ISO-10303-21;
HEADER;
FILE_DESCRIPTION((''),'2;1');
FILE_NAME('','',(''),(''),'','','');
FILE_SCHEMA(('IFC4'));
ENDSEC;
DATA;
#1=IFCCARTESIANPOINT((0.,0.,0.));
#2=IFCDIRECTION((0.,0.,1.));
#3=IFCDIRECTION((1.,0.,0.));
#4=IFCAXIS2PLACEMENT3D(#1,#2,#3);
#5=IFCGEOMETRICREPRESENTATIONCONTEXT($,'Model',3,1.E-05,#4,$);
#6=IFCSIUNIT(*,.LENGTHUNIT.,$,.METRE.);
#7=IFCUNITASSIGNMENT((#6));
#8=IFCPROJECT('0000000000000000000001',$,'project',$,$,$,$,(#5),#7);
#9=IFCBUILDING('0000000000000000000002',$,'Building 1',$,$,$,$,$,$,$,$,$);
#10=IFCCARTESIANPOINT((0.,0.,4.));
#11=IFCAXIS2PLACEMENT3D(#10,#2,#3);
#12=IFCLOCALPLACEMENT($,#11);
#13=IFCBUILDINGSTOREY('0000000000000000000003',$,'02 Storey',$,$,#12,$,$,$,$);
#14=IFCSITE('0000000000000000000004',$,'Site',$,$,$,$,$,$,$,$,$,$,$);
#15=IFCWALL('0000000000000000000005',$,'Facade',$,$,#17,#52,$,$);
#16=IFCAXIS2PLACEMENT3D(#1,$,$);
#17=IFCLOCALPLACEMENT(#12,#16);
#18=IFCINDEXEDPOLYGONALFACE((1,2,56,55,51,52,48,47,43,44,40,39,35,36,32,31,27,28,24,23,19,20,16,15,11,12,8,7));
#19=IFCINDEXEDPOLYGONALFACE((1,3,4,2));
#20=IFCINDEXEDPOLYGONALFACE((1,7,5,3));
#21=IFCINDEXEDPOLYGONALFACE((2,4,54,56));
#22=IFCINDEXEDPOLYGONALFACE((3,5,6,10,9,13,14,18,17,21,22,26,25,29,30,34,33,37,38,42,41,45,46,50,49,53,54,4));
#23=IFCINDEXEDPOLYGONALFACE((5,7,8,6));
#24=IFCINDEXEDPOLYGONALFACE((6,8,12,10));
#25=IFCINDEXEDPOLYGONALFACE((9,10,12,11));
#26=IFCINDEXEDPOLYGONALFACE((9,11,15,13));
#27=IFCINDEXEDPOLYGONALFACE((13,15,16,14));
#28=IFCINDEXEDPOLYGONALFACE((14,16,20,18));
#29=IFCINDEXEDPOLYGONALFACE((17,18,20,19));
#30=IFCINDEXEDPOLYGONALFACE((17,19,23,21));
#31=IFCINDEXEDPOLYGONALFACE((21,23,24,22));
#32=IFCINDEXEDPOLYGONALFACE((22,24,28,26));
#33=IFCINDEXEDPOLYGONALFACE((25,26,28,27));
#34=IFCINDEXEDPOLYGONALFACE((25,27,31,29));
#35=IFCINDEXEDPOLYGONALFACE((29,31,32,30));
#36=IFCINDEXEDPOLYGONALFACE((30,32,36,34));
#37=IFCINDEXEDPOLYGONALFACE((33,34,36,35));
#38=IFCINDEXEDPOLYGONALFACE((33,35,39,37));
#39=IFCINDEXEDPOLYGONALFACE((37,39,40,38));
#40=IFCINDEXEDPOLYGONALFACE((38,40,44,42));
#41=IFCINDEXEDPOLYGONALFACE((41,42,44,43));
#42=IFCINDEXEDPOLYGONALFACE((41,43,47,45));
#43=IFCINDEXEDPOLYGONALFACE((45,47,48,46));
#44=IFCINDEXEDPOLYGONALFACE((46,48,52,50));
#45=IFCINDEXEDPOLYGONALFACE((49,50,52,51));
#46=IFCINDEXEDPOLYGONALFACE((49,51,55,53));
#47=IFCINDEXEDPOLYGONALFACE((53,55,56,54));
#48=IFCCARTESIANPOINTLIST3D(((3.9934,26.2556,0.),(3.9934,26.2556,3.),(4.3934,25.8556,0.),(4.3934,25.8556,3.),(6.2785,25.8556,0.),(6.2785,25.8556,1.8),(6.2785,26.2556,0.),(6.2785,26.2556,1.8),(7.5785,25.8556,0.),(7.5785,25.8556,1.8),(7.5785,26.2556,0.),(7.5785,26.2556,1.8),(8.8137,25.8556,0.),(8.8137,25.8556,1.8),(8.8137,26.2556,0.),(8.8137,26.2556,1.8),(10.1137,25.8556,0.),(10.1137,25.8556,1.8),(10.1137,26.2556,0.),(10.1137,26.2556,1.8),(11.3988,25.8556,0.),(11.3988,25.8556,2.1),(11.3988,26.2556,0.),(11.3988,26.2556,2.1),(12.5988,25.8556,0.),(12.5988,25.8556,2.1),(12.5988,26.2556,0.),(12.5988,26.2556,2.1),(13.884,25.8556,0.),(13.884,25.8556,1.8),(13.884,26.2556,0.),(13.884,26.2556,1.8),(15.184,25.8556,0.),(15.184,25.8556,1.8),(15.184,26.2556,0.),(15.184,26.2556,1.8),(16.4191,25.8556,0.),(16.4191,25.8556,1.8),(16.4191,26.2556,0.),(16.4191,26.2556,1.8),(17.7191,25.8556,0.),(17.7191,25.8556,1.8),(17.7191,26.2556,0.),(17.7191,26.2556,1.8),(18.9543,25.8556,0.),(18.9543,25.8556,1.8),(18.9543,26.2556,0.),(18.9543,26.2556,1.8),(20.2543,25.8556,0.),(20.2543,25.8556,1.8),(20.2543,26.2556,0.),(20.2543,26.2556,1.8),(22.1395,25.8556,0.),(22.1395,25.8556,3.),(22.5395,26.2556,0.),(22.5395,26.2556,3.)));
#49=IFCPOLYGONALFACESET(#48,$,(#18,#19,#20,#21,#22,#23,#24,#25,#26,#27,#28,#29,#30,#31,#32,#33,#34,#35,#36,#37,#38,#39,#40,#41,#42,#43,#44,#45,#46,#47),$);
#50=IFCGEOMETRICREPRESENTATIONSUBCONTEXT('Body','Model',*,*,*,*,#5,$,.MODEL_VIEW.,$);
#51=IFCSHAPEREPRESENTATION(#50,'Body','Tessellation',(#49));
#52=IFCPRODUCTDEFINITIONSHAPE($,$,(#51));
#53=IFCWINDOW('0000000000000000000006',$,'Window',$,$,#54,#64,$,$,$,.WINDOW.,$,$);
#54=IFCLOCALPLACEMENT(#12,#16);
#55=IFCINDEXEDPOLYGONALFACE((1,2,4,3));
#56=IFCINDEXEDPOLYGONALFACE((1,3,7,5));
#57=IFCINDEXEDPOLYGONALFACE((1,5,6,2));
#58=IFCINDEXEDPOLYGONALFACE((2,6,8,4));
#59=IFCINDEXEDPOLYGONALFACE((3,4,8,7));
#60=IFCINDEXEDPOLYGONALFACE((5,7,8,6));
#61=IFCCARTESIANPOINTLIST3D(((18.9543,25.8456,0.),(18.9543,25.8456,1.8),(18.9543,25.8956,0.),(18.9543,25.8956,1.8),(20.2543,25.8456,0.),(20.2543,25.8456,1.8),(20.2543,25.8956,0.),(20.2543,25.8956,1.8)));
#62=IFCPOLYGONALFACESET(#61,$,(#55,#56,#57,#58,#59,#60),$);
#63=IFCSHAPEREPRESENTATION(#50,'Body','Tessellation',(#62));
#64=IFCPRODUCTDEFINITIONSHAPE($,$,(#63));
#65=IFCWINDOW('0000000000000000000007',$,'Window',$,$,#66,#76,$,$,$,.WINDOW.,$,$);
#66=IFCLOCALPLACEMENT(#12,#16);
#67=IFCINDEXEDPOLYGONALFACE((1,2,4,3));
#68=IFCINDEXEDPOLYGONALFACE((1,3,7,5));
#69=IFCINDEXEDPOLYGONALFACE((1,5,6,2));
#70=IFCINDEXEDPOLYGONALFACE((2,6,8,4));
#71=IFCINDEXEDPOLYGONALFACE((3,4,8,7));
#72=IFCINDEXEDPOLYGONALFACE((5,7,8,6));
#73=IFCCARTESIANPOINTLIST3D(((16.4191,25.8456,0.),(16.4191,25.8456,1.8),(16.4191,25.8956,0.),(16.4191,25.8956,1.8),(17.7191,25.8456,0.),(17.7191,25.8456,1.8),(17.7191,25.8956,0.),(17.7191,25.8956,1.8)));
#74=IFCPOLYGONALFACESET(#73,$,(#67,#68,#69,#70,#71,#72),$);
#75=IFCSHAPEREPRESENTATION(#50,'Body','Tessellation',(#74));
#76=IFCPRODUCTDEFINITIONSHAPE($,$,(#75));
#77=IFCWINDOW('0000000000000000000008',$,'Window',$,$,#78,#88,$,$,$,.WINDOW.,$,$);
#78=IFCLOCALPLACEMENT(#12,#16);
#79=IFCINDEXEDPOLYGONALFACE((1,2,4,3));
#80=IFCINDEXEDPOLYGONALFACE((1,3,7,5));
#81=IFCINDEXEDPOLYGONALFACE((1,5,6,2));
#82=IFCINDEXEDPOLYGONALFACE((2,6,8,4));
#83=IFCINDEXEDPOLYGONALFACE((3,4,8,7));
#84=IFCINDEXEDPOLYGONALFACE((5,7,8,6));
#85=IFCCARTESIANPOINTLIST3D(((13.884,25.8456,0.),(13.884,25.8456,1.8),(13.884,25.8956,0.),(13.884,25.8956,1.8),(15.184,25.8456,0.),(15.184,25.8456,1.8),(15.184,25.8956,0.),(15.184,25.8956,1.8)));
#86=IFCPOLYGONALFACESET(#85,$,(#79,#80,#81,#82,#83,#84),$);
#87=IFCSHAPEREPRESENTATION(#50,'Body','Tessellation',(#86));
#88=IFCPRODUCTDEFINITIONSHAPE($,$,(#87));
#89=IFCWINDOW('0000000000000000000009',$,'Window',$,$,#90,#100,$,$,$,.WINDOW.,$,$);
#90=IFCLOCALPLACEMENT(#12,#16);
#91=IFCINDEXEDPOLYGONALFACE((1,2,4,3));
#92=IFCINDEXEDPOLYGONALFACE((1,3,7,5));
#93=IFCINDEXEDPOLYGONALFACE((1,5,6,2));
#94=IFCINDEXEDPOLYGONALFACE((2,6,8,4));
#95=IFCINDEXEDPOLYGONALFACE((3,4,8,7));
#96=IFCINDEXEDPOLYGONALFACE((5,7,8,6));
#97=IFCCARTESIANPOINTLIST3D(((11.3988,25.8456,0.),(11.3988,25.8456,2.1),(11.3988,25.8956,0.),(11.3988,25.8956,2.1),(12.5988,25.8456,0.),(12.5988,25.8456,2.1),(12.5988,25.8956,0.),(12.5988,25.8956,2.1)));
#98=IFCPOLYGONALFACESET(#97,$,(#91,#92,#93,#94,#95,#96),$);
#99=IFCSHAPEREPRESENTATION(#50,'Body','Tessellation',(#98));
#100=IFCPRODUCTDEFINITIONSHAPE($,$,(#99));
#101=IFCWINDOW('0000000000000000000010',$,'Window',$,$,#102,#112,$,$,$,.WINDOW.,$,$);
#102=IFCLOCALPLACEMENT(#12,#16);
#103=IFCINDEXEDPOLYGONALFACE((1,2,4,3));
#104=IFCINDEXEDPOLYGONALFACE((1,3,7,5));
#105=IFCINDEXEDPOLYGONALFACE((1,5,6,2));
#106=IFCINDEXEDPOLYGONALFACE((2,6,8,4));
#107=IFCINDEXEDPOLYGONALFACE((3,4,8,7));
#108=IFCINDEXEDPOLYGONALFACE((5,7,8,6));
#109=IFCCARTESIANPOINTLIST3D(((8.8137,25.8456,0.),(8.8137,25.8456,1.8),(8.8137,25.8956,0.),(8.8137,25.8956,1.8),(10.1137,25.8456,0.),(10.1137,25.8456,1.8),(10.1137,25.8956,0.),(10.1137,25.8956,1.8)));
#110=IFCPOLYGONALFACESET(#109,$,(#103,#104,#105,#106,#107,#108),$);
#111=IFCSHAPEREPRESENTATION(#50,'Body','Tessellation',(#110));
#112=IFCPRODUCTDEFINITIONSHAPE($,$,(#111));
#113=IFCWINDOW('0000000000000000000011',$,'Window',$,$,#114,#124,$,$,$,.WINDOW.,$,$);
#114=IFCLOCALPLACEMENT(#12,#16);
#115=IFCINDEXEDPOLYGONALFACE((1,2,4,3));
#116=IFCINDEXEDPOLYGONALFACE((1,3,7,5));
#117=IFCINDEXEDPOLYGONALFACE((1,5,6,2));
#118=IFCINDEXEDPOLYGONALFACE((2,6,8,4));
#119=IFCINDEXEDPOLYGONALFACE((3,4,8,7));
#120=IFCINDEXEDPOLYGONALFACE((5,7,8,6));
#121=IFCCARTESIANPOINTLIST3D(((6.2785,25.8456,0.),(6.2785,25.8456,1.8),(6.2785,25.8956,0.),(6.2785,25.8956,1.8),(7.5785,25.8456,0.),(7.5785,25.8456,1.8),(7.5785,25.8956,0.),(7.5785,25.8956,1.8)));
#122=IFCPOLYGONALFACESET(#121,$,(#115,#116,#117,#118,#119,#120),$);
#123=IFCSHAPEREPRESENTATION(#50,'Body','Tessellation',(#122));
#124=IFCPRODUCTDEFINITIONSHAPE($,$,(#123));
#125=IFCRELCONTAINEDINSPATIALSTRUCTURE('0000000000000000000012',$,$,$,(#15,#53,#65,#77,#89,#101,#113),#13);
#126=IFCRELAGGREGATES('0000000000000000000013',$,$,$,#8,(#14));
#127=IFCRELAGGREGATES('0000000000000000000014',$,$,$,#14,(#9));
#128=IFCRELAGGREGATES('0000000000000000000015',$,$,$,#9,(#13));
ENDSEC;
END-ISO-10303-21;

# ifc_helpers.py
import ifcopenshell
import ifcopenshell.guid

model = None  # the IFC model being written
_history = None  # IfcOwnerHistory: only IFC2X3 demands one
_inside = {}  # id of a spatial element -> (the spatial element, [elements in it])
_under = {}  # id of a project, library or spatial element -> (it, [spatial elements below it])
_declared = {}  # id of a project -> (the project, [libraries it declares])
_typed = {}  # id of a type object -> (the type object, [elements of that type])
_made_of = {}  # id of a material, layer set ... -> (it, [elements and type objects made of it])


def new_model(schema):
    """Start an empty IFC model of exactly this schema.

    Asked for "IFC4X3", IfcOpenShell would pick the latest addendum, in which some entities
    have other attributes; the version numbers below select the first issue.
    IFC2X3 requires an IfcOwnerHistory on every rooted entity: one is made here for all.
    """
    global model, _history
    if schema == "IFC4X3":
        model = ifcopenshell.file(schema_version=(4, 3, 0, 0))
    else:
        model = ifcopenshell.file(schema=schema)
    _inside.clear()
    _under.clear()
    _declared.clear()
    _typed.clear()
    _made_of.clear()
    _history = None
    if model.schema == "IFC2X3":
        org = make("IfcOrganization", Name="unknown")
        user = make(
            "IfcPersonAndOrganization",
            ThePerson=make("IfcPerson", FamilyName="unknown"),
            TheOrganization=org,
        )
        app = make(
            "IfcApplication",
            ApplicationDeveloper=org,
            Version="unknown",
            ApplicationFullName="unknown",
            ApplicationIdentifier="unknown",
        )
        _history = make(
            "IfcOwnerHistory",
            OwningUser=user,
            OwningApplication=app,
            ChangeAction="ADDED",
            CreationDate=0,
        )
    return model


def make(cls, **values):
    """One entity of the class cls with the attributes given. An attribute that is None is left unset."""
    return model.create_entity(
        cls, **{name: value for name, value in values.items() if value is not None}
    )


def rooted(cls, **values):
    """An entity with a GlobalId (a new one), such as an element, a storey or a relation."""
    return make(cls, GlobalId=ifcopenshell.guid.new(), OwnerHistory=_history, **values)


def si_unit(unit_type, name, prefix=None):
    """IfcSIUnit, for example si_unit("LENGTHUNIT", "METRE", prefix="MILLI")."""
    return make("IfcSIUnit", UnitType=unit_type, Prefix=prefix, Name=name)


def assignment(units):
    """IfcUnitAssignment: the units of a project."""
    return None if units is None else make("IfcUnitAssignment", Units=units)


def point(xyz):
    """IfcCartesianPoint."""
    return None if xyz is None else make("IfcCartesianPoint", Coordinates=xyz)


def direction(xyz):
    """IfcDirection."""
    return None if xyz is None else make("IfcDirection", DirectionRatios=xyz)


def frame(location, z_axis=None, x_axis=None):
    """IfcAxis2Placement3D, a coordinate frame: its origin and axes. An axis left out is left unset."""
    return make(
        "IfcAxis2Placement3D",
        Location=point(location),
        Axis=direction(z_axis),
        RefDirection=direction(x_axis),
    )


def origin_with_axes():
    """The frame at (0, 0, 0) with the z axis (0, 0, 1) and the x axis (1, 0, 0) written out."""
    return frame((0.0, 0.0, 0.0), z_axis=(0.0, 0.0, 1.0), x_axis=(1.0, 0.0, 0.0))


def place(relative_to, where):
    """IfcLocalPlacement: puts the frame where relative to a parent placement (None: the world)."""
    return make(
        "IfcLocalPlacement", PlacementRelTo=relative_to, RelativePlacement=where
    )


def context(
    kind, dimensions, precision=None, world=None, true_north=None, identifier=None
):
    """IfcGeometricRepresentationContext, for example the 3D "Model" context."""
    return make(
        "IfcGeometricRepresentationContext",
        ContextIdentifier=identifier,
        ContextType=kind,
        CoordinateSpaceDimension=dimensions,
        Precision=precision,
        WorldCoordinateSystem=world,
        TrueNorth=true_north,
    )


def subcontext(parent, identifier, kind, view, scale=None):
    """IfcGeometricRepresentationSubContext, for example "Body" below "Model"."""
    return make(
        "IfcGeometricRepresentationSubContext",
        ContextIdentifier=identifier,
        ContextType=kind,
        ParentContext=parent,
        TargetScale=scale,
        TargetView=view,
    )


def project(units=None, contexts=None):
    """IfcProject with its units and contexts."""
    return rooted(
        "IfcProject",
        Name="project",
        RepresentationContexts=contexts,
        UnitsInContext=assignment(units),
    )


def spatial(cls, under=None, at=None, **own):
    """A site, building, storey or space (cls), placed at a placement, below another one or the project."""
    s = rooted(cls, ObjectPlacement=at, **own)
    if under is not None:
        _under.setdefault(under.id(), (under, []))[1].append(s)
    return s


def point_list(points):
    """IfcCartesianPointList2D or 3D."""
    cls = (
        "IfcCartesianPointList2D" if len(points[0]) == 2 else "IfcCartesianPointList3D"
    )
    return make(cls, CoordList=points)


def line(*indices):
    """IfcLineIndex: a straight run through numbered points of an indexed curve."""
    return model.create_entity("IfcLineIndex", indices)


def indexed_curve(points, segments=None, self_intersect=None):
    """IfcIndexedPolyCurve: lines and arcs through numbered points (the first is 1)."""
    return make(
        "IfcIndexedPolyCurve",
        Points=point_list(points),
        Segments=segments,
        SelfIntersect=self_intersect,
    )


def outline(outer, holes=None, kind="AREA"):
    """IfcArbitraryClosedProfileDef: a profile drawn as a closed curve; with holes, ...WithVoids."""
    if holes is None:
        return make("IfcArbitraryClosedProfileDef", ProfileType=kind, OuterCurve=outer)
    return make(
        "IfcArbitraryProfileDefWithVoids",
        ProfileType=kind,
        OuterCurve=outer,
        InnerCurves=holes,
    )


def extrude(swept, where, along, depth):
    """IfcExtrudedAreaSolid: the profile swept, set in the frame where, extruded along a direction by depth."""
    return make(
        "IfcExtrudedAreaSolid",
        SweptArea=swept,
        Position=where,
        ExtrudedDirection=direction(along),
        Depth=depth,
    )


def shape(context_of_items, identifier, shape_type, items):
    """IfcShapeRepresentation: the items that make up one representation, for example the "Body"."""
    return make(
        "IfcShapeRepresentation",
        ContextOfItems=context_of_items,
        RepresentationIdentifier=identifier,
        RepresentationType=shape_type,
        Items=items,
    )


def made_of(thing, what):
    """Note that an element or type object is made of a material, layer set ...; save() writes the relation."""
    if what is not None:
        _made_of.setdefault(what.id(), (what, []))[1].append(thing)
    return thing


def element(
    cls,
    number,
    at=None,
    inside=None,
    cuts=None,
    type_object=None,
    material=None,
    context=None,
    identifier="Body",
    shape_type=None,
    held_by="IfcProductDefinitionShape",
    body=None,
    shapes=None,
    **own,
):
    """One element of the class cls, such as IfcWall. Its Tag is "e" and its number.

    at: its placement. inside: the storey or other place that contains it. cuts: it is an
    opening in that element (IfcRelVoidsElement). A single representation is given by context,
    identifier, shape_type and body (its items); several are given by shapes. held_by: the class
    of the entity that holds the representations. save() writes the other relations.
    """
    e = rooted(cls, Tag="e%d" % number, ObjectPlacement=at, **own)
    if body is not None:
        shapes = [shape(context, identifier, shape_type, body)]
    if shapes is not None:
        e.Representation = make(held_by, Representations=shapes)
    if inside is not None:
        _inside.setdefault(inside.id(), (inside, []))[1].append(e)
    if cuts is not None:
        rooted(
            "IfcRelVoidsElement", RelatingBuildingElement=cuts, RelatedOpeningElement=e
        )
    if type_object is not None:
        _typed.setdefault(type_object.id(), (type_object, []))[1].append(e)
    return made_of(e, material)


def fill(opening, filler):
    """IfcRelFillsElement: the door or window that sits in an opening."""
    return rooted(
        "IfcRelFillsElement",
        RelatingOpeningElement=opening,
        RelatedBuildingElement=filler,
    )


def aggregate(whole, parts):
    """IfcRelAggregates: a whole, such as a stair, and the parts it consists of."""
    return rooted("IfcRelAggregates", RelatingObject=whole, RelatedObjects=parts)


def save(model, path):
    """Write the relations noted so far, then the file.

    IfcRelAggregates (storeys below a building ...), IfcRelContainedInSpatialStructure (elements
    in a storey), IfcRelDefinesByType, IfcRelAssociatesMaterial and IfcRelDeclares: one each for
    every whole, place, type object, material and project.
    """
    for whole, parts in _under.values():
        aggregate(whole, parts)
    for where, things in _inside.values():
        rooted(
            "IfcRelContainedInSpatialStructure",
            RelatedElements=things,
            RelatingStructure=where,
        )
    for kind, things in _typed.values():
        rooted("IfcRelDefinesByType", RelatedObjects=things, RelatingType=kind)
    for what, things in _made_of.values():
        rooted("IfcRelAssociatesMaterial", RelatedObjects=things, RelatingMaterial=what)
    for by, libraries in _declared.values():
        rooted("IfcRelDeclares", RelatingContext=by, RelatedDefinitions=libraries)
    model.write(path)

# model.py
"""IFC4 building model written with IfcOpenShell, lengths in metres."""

from ifc_helpers import new_model, si_unit, frame, origin_with_axes, place, context, subcontext, project, spatial, line, indexed_curve, outline, extrude, element, fill, save


model = new_model("IFC4")

# Units and contexts
model_context = context("Model", 3, precision=1e-05, world=origin_with_axes())
body_context = subcontext(model_context, "Body", "Model", "MODEL_VIEW")
ifc_project = project(units=[si_unit("LENGTHUNIT", "METRE")], contexts=[model_context])

# Site, building, storey
site = spatial("IfcSite", under=ifc_project, Name="Site")
building = spatial("IfcBuilding", under=site, Name="Building 1")
storey_placement = place(None, frame((0.0, 0.0, 4.0), z_axis=(0.0, 0.0, 1.0), x_axis=(1.0, 0.0, 0.0)))
storey = spatial("IfcBuildingStorey", under=building, at=storey_placement, Name="02 Storey")

# Wall, openings, windows
wall_1_placement = place(storey_placement, origin_with_axes())
wall_1 = element("IfcWall", 1, at=wall_1_placement, inside=storey, Name="Facade", context=body_context, shape_type="SweptSolid", body=[
    extrude(outline(indexed_curve([(22.1395, 25.8556), (4.3934, 25.8556), (3.9934, 26.2556), (22.5395, 26.2556)], segments=[line(1, 2), line(2, 3), line(3, 4)])), origin_with_axes(), (0.0, 0.0, 1.0), 3.0),
])
opening_1_placement = place(wall_1_placement, origin_with_axes())
opening_1 = element("IfcOpeningElement", 2, at=opening_1_placement, cuts=wall_1, context=body_context, shape_type="SweptSolid", body=[
    extrude(outline(indexed_curve([(20.2543, 26.2956), (20.2543, 25.7956), (18.9543, 25.7956), (18.9543, 26.2956)], segments=[line(1, 2), line(2, 3), line(3, 4)])), origin_with_axes(), (0.0, 0.0, 1.0), 1.8),
])
opening_2_placement = place(wall_1_placement, origin_with_axes())
opening_2 = element("IfcOpeningElement", 3, at=opening_2_placement, cuts=wall_1, context=body_context, shape_type="SweptSolid", body=[
    extrude(outline(indexed_curve([(17.7191, 26.2956), (17.7191, 25.7956), (16.4191, 25.7956), (16.4191, 26.2956)], segments=[line(1, 2), line(2, 3), line(3, 4)])), origin_with_axes(), (0.0, 0.0, 1.0), 1.8),
])
opening_3_placement = place(wall_1_placement, origin_with_axes())
opening_3 = element("IfcOpeningElement", 4, at=opening_3_placement, cuts=wall_1, context=body_context, shape_type="SweptSolid", body=[
    extrude(outline(indexed_curve([(15.184, 26.2956), (15.184, 25.7956), (13.884, 25.7956), (13.884, 26.2956)], segments=[line(1, 2), line(2, 3), line(3, 4)])), origin_with_axes(), (0.0, 0.0, 1.0), 1.8),
])
opening_4_placement = place(wall_1_placement, origin_with_axes())
opening_4 = element("IfcOpeningElement", 5, at=opening_4_placement, cuts=wall_1, context=body_context, shape_type="SweptSolid", body=[
    extrude(outline(indexed_curve([(12.5988, 26.2956), (12.5988, 25.7956), (11.3988, 25.7956), (11.3988, 26.2956)], segments=[line(1, 2), line(2, 3), line(3, 4)])), origin_with_axes(), (0.0, 0.0, 1.0), 2.1),
])
opening_5_placement = place(wall_1_placement, origin_with_axes())
opening_5 = element("IfcOpeningElement", 6, at=opening_5_placement, cuts=wall_1, context=body_context, shape_type="SweptSolid", body=[
    extrude(outline(indexed_curve([(10.1137, 26.2956), (10.1137, 25.7956), (8.8137, 25.7956), (8.8137, 26.2956)], segments=[line(1, 2), line(2, 3), line(3, 4)])), origin_with_axes(), (0.0, 0.0, 1.0), 1.8),
])
opening_6_placement = place(wall_1_placement, origin_with_axes())
opening_6 = element("IfcOpeningElement", 7, at=opening_6_placement, cuts=wall_1, context=body_context, shape_type="SweptSolid", body=[
    extrude(outline(indexed_curve([(7.5785, 26.2956), (7.5785, 25.7956), (6.2785, 25.7956), (6.2785, 26.2956)], segments=[line(1, 2), line(2, 3), line(3, 4)])), origin_with_axes(), (0.0, 0.0, 1.0), 1.8),
])
window_1_placement = place(storey_placement, origin_with_axes())
window_1 = element("IfcWindow", 8, at=window_1_placement, inside=storey, Name="Window", PredefinedType="WINDOW", context=body_context, shape_type="SweptSolid", body=[
    extrude(outline(indexed_curve([(20.2543, 25.8956), (20.2543, 25.8456), (18.9543, 25.8456), (18.9543, 25.8956)], segments=[line(1, 2), line(2, 3), line(3, 4)])), origin_with_axes(), (0.0, 0.0, 1.0), 1.8),
])
fill(opening_1, window_1)
window_2_placement = place(storey_placement, origin_with_axes())
window_2 = element("IfcWindow", 9, at=window_2_placement, inside=storey, Name="Window", PredefinedType="WINDOW", context=body_context, shape_type="SweptSolid", body=[
    extrude(outline(indexed_curve([(17.7191, 25.8956), (17.7191, 25.8456), (16.4191, 25.8456), (16.4191, 25.8956)], segments=[line(1, 2), line(2, 3), line(3, 4)])), origin_with_axes(), (0.0, 0.0, 1.0), 1.8),
])
fill(opening_2, window_2)
window_3_placement = place(storey_placement, origin_with_axes())
window_3 = element("IfcWindow", 10, at=window_3_placement, inside=storey, Name="Window", PredefinedType="WINDOW", context=body_context, shape_type="SweptSolid", body=[
    extrude(outline(indexed_curve([(15.184, 25.8956), (15.184, 25.8456), (13.884, 25.8456), (13.884, 25.8956)], segments=[line(1, 2), line(2, 3), line(3, 4)])), origin_with_axes(), (0.0, 0.0, 1.0), 1.8),
])
fill(opening_3, window_3)
window_4_placement = place(storey_placement, origin_with_axes())
window_4 = element("IfcWindow", 11, at=window_4_placement, inside=storey, Name="Window", PredefinedType="WINDOW", context=body_context, shape_type="SweptSolid", body=[
    extrude(outline(indexed_curve([(12.5988, 25.8956), (12.5988, 25.8456), (11.3988, 25.8456), (11.3988, 25.8956)], segments=[line(1, 2), line(2, 3), line(3, 4)])), origin_with_axes(), (0.0, 0.0, 1.0), 2.1),
])
fill(opening_4, window_4)
window_5_placement = place(storey_placement, origin_with_axes())
window_5 = element("IfcWindow", 12, at=window_5_placement, inside=storey, Name="Window", PredefinedType="WINDOW", context=body_context, shape_type="SweptSolid", body=[
    extrude(outline(indexed_curve([(10.1137, 25.8956), (10.1137, 25.8456), (8.8137, 25.8456), (8.8137, 25.8956)], segments=[line(1, 2), line(2, 3), line(3, 4)])), origin_with_axes(), (0.0, 0.0, 1.0), 1.8),
])
fill(opening_5, window_5)
window_6_placement = place(storey_placement, origin_with_axes())
window_6 = element("IfcWindow", 13, at=window_6_placement, inside=storey, Name="Window", PredefinedType="WINDOW", context=body_context, shape_type="SweptSolid", body=[
    extrude(outline(indexed_curve([(7.5785, 25.8956), (7.5785, 25.8456), (6.2785, 25.8456), (6.2785, 25.8956)], segments=[line(1, 2), line(2, 3), line(3, 4)])), origin_with_axes(), (0.0, 0.0, 1.0), 1.8),
])
fill(opening_6, window_6)

save(model, "model.ifc")
